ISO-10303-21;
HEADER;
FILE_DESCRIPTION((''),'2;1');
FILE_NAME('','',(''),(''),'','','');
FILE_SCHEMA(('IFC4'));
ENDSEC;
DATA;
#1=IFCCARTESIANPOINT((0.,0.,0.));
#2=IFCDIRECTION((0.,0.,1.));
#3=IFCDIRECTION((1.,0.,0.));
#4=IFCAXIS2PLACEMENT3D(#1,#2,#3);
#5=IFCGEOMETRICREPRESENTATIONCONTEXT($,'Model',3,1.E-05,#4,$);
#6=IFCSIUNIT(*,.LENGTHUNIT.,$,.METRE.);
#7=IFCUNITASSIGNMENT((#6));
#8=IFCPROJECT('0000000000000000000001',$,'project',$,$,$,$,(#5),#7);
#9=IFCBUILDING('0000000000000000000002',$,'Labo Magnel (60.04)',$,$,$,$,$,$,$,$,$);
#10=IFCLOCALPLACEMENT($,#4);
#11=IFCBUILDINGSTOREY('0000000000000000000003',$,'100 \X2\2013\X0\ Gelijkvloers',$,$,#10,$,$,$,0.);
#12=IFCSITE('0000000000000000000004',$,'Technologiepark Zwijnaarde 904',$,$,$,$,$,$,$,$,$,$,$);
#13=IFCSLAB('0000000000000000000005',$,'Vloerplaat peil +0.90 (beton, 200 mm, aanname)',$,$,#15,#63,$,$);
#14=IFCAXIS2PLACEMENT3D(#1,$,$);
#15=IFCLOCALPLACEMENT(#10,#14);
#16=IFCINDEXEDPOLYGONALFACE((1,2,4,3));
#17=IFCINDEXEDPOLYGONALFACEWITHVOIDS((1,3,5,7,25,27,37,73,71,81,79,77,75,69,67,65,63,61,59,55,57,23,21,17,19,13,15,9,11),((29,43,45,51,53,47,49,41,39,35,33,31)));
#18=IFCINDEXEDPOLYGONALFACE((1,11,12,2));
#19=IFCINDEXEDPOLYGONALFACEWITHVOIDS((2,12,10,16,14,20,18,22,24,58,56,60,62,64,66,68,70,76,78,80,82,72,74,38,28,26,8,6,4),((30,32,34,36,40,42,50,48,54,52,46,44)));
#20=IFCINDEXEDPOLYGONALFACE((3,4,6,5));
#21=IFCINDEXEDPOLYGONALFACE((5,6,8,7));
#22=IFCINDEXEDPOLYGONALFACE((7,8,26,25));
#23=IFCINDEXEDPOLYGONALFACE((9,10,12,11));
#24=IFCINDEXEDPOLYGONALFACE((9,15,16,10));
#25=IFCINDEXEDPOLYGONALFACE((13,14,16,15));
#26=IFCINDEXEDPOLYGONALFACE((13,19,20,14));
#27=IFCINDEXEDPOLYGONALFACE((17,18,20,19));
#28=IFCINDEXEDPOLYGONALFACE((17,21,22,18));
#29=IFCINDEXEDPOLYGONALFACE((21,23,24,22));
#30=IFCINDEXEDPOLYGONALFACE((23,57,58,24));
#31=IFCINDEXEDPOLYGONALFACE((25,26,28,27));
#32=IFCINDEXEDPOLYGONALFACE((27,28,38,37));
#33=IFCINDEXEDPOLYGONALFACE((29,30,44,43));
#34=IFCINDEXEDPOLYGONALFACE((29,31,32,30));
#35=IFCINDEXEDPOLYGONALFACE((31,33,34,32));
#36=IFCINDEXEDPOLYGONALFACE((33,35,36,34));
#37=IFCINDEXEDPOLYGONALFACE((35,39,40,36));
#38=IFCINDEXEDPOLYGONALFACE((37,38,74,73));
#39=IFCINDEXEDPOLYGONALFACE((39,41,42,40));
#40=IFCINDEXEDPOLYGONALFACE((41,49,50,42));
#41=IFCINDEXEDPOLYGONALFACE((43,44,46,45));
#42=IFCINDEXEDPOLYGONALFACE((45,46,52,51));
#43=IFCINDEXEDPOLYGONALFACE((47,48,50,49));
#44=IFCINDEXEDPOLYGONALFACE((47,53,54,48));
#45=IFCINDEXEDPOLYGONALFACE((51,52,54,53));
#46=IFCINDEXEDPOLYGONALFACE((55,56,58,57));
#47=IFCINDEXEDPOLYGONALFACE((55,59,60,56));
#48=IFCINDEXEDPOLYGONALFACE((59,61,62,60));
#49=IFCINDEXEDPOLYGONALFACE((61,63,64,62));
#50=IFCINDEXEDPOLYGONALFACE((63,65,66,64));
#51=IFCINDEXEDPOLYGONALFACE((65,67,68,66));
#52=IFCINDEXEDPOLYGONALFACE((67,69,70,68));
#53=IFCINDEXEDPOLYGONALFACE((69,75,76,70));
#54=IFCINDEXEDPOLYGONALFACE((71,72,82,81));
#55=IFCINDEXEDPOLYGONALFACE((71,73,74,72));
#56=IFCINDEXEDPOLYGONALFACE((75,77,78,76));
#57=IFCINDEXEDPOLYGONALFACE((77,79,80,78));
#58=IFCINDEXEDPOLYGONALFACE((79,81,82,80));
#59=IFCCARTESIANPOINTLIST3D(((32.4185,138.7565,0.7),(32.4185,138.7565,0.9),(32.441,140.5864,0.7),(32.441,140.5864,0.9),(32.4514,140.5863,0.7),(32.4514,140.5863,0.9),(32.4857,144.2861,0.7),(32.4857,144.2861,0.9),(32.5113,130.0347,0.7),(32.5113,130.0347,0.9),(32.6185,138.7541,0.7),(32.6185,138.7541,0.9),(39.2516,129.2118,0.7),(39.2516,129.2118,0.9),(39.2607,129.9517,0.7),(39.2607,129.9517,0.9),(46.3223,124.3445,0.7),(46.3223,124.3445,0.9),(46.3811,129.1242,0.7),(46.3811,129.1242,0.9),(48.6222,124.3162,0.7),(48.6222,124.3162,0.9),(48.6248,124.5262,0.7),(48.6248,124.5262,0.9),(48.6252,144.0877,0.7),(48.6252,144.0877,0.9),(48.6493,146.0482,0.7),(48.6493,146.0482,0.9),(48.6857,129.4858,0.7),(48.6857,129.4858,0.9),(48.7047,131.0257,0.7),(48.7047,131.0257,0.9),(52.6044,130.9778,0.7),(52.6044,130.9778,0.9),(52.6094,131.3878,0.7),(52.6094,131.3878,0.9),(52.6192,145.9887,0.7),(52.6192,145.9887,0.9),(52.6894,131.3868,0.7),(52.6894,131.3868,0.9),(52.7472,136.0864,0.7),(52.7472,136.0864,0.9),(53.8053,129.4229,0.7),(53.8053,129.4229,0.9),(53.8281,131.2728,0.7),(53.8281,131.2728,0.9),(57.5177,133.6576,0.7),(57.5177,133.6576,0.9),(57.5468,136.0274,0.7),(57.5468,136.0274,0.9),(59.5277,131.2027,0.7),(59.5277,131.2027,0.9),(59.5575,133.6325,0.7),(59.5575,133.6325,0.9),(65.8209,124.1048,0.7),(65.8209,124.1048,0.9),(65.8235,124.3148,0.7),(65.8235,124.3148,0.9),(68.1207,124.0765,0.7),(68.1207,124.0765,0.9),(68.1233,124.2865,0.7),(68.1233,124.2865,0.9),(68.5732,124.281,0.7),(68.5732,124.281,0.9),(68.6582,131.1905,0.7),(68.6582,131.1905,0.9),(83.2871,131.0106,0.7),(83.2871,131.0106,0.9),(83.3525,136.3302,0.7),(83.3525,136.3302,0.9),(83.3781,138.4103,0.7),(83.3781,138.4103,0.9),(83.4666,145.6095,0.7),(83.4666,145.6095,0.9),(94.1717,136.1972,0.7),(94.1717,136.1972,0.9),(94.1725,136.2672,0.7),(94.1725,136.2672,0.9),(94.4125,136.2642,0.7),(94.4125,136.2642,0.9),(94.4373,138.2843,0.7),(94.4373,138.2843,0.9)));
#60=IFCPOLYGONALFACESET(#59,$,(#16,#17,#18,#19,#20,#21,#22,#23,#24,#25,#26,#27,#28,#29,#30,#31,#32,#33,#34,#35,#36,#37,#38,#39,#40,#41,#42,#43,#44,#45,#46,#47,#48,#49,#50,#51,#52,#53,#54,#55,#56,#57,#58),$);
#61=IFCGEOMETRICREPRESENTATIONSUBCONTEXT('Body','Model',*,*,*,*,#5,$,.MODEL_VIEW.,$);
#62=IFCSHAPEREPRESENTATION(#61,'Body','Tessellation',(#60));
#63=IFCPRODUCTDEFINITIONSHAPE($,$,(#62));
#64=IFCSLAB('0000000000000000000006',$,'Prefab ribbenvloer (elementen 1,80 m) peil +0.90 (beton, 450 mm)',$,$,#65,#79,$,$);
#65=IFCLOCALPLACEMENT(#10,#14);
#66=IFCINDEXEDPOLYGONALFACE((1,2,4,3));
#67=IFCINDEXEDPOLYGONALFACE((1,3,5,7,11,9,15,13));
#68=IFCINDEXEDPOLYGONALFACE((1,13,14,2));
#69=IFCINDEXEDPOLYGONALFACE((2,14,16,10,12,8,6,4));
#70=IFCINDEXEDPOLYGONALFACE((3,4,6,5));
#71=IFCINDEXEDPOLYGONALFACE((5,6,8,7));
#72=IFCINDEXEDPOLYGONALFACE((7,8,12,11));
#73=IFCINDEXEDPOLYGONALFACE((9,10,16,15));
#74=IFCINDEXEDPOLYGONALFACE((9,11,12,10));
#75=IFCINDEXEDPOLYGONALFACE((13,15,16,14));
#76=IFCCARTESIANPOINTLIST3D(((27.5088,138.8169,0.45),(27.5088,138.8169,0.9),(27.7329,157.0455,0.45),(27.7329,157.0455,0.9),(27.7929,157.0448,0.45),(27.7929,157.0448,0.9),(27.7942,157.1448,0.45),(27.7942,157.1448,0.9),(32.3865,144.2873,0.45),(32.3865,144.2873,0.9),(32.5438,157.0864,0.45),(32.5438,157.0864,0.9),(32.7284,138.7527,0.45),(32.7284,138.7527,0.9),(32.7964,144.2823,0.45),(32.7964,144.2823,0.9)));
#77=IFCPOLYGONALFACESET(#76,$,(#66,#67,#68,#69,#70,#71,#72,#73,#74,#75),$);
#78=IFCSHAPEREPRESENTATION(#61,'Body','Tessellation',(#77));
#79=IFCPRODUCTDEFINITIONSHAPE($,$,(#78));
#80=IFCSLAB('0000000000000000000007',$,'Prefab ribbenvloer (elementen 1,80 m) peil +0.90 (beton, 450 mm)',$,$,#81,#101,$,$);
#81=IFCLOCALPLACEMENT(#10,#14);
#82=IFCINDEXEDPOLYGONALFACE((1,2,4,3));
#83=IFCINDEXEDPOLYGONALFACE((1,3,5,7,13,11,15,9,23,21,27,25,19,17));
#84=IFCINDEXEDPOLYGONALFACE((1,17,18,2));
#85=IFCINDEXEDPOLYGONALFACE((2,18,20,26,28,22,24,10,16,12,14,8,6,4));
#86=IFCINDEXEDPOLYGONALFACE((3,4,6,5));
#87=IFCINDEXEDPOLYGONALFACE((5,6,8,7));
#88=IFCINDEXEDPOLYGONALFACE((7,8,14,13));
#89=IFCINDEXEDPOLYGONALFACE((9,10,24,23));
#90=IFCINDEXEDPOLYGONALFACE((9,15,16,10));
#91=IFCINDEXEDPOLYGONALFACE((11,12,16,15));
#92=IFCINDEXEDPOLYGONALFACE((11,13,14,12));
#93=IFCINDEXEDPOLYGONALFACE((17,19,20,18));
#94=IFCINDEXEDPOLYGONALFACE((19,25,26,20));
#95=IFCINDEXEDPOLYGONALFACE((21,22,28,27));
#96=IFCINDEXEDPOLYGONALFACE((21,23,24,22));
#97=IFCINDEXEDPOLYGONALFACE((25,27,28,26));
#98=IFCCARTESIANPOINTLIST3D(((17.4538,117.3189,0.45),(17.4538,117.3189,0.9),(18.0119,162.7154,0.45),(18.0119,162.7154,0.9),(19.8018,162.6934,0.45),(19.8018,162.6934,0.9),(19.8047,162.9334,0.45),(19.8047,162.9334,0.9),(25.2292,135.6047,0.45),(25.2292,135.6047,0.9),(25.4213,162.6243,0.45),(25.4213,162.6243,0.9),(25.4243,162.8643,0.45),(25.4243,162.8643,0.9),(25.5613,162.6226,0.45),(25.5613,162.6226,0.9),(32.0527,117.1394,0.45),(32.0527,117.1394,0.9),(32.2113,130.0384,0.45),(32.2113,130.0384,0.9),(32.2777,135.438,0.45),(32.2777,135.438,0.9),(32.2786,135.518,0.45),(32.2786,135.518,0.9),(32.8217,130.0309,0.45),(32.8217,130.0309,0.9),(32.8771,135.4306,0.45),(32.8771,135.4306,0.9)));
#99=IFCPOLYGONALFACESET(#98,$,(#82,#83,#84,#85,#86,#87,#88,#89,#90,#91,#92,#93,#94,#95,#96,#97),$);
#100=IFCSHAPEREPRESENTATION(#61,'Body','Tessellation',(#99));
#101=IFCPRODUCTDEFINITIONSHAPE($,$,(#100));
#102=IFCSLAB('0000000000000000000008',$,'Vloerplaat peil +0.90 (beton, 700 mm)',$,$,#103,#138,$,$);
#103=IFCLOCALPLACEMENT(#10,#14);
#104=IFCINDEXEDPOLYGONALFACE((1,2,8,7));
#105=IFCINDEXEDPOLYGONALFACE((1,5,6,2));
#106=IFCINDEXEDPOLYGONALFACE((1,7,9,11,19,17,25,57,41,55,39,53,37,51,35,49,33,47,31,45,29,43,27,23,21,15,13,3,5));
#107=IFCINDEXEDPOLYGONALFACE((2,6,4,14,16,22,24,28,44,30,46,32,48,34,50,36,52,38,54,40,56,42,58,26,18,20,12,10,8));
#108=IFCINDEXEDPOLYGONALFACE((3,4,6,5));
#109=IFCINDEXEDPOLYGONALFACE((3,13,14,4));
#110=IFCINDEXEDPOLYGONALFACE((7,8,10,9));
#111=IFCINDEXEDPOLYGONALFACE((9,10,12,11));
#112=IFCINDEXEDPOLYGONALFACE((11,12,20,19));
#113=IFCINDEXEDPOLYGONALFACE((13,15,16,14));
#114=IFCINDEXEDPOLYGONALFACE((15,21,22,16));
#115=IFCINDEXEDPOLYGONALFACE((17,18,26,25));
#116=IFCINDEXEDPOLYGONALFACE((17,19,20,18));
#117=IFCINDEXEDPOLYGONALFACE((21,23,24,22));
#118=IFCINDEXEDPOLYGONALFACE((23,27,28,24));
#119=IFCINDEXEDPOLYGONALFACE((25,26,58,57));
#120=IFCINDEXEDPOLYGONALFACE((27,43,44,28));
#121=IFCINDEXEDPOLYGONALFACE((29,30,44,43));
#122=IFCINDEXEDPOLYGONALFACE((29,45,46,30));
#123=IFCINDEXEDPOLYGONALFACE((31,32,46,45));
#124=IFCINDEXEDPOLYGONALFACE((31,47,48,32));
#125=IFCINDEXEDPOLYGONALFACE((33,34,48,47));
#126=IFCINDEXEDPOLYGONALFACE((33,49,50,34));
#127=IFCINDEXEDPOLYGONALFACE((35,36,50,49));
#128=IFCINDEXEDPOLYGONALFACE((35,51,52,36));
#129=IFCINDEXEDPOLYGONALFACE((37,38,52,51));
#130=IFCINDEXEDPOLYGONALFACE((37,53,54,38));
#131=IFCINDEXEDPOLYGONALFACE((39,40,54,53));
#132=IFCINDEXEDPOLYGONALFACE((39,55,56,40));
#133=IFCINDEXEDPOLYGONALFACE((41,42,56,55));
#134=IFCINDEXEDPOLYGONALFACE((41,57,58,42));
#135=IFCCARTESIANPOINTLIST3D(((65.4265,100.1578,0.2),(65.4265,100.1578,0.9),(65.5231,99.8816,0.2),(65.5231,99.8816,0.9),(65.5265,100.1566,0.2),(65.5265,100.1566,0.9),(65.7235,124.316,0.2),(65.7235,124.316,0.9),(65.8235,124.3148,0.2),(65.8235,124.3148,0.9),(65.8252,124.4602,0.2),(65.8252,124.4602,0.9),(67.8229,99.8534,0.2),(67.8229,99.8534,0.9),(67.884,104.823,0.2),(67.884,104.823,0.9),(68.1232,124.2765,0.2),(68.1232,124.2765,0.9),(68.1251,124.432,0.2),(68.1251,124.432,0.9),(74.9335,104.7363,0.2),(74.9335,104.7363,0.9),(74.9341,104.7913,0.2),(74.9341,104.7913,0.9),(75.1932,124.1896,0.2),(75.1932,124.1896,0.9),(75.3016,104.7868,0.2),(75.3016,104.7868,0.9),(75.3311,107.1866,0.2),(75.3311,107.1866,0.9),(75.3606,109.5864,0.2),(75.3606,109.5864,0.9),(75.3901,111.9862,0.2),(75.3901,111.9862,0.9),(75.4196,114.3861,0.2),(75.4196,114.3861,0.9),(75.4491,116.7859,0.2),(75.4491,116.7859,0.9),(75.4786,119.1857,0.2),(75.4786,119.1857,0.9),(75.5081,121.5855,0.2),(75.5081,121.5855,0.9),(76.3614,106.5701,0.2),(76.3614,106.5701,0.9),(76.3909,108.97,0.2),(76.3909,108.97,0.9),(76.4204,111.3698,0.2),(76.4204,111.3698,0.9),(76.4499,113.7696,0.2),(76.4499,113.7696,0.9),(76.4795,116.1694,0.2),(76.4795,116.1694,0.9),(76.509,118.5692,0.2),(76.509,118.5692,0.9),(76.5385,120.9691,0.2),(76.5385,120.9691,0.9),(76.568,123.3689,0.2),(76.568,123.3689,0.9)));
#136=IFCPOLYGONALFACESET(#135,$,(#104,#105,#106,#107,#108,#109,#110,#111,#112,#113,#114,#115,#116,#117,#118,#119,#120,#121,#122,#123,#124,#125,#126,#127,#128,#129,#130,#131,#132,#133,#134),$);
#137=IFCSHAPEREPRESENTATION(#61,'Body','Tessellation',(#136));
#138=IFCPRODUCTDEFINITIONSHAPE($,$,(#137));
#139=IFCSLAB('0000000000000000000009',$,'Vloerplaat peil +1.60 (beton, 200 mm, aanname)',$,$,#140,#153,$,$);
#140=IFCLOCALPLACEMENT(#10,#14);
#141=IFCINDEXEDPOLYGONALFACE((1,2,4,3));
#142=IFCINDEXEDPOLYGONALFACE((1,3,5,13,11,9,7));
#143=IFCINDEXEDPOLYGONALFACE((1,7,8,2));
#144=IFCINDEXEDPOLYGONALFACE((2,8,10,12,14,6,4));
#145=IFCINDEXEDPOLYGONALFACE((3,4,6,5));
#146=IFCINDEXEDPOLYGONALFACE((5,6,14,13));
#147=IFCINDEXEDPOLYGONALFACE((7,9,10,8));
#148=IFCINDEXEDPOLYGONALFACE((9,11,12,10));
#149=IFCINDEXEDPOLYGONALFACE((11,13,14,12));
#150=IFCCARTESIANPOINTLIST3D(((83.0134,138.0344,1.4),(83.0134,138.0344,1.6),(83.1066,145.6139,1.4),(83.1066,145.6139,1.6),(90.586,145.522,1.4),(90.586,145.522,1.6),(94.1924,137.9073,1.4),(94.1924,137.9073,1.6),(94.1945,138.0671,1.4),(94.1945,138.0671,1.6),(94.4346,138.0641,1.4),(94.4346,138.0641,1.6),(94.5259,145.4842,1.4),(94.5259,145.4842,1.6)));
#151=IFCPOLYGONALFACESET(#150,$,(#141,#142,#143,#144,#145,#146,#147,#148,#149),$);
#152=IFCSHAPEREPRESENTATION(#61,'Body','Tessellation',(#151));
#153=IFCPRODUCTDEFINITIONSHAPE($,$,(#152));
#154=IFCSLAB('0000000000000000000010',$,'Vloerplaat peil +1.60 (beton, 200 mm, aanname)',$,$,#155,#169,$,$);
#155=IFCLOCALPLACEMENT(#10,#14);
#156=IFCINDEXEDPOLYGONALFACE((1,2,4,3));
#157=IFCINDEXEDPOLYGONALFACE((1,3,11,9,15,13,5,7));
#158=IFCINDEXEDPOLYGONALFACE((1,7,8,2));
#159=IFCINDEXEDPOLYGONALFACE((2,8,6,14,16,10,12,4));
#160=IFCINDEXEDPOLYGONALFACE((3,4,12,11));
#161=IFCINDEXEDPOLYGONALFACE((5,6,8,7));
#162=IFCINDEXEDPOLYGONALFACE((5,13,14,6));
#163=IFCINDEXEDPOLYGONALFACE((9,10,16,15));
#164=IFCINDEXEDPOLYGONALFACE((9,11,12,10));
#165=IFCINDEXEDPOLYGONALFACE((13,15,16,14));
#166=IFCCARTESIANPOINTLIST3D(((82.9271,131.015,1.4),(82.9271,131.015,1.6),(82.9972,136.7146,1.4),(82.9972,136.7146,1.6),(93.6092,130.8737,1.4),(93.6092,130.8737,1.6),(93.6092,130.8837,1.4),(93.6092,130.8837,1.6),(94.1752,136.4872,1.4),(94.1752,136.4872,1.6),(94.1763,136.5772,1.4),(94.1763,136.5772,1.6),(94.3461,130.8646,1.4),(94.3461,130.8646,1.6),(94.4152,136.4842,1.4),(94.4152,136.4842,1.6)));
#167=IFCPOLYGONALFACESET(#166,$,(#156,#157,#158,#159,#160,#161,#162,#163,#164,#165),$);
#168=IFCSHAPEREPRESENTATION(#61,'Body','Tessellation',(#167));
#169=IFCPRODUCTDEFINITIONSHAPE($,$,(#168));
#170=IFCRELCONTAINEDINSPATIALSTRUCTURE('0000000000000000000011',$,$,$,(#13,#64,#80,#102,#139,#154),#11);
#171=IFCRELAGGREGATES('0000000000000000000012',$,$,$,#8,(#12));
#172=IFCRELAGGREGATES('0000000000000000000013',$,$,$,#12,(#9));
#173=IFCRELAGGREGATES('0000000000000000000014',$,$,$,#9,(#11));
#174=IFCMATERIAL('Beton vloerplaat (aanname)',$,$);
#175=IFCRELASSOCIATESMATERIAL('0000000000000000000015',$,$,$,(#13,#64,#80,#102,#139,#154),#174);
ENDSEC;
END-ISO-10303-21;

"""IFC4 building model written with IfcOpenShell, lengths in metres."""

from ifc_helpers import new_model, si_unit, frame, origin, origin_with_axes, place, context, subcontext, project, spatial, polyline, outline, extrude, material, element, save


model = new_model("IFC4")

# Units and contexts
model_context = context("Model", 3, precision=1e-05, world=origin_with_axes())
body_context = subcontext(model_context, "Body", "Model", "MODEL_VIEW")
ifc_project = project(units=[si_unit("LENGTHUNIT", "METRE")], contexts=[model_context])

# Site, building, storey
site = spatial("IfcSite", under=ifc_project, Name="Technologiepark Zwijnaarde 904")
building = spatial("IfcBuilding", under=site, Name="Labo Magnel (60.04)")
storey_placement = place(None, origin_with_axes())
storey = spatial("IfcBuildingStorey", under=building, at=storey_placement, Name="100 – Gelijkvloers", Elevation=0.0)

# Slabs
ifc_material_1 = material(Name="Beton vloerplaat (aanname)")
slab_1_placement = place(storey_placement, frame((0.0, 0.0, 0.7), z_axis=(0.0, 0.0, 1.0), x_axis=(1.0, 0.0, 0.0)))
element("IfcSlab", 1, at=slab_1_placement, inside=storey, material=ifc_material_1, Name="Vloerplaat peil +0.90 (beton, 200 mm, aanname)", context=body_context, shape_type="SweptSolid", body=[
    extrude(outline(polyline([(32.4185, 138.7565), (32.441, 140.5864), (32.4514, 140.5863), (32.4857, 144.2861), (48.6252, 144.0877), (48.6493, 146.0482), (52.6192, 145.9887), (83.4666, 145.6095), (83.3781, 138.4103), (94.4373, 138.2843), (94.4125, 136.2642), (94.1725, 136.2672), (94.1717, 136.1972), (83.3525, 136.3302), (83.2871, 131.0106), (68.6582, 131.1905), (68.5732, 124.281), (68.1233, 124.2865), (68.1207, 124.0765), (65.8209, 124.1048), (65.8235, 124.3148), (48.6248, 124.5262), (48.6222, 124.3162), (46.3223, 124.3445), (46.3811, 129.1242), (39.2516, 129.2118), (39.2607, 129.9517), (32.5113, 130.0347), (32.6185, 138.7541), (32.4185, 138.7565)]), holes=[polyline([(48.7047, 131.0257), (48.6857, 129.4858), (53.8053, 129.4229), (53.8281, 131.2728), (59.5277, 131.2027), (59.5575, 133.6325), (57.5177, 133.6576), (57.5468, 136.0274), (52.7472, 136.0864), (52.6894, 131.3868), (52.6094, 131.3878), (52.6044, 130.9778), (48.7047, 131.0257)])]), origin(), (0.0, 0.0, 1.0), 0.2),
])
slab_2_placement = place(storey_placement, frame((0.0, 0.0, 0.45), z_axis=(0.0, 0.0, 1.0), x_axis=(1.0, 0.0, 0.0)))
element("IfcSlab", 2, at=slab_2_placement, inside=storey, material=ifc_material_1, Name="Prefab ribbenvloer (elementen 1,80 m) peil +0.90 (beton, 450 mm)", context=body_context, shape_type="SweptSolid", body=[
    extrude(outline(polyline([(27.7942, 157.1448), (32.5438, 157.0864), (32.3865, 144.2873), (32.7964, 144.2823), (32.7284, 138.7527), (27.5088, 138.8169), (27.7329, 157.0455), (27.7929, 157.0448), (27.7942, 157.1448)])), origin(), (0.0, 0.0, 1.0), 0.45),
])
slab_3_placement = place(storey_placement, frame((0.0, 0.0, 0.45), z_axis=(0.0, 0.0, 1.0), x_axis=(1.0, 0.0, 0.0)))
element("IfcSlab", 3, at=slab_3_placement, inside=storey, material=ifc_material_1, Name="Prefab ribbenvloer (elementen 1,80 m) peil +0.90 (beton, 450 mm)", context=body_context, shape_type="SweptSolid", body=[
    extrude(outline(polyline([(17.4538, 117.3189), (18.0119, 162.7154), (19.8018, 162.6934), (19.8047, 162.9334), (25.4243, 162.8643), (25.4213, 162.6243), (25.5613, 162.6226), (25.2292, 135.6047), (32.2786, 135.518), (32.2777, 135.438), (32.8771, 135.4306), (32.8217, 130.0309), (32.2113, 130.0384), (32.0527, 117.1394), (17.4538, 117.3189)])), origin(), (0.0, 0.0, 1.0), 0.45),
])
slab_4_placement = place(storey_placement, frame((0.0, 0.0, 0.2), z_axis=(0.0, 0.0, 1.0), x_axis=(1.0, 0.0, 0.0)))
element("IfcSlab", 4, at=slab_4_placement, inside=storey, material=ifc_material_1, Name="Vloerplaat peil +0.90 (beton, 700 mm)", context=body_context, shape_type="SweptSolid", body=[
    extrude(outline(polyline([(65.5231, 99.8816), (65.5265, 100.1566), (65.4265, 100.1578), (65.7235, 124.316), (65.8235, 124.3148), (65.8252, 124.4602), (68.1251, 124.432), (68.1232, 124.2765), (75.1932, 124.1896), (76.568, 123.3689), (75.5081, 121.5855), (76.5385, 120.9691), (75.4786, 119.1857), (76.509, 118.5692), (75.4491, 116.7859), (76.4795, 116.1694), (75.4196, 114.3861), (76.4499, 113.7696), (75.3901, 111.9862), (76.4204, 111.3698), (75.3606, 109.5864), (76.3909, 108.97), (75.3311, 107.1866), (76.3614, 106.5701), (75.3016, 104.7868), (74.9341, 104.7913), (74.9335, 104.7363), (67.884, 104.823), (67.8229, 99.8534), (65.5231, 99.8816)])), origin(), (0.0, 0.0, 1.0), 0.7),
])
slab_5_placement = place(storey_placement, frame((0.0, 0.0, 1.4), z_axis=(0.0, 0.0, 1.0), x_axis=(1.0, 0.0, 0.0)))
element("IfcSlab", 5, at=slab_5_placement, inside=storey, material=ifc_material_1, Name="Vloerplaat peil +1.60 (beton, 200 mm, aanname)", context=body_context, shape_type="SweptSolid", body=[
    extrude(outline(polyline([(83.1066, 145.6139), (90.586, 145.522), (94.5259, 145.4842), (94.4346, 138.0641), (94.1945, 138.0671), (94.1924, 137.9073), (83.0134, 138.0344), (83.1066, 145.6139)])), origin(), (0.0, 0.0, 1.0), 0.2),
])
slab_6_placement = place(storey_placement, frame((0.0, 0.0, 1.4), z_axis=(0.0, 0.0, 1.0), x_axis=(1.0, 0.0, 0.0)))
element("IfcSlab", 6, at=slab_6_placement, inside=storey, material=ifc_material_1, Name="Vloerplaat peil +1.60 (beton, 200 mm, aanname)", context=body_context, shape_type="SweptSolid", body=[
    extrude(outline(polyline([(93.6092, 130.8837), (82.9271, 131.015), (82.9972, 136.7146), (94.1763, 136.5772), (94.1752, 136.4872), (94.4152, 136.4842), (94.3461, 130.8646), (93.6092, 130.8737), (93.6092, 130.8837)])), origin(), (0.0, 0.0, 1.0), 0.2),
])

save(model, "model.ifc")
